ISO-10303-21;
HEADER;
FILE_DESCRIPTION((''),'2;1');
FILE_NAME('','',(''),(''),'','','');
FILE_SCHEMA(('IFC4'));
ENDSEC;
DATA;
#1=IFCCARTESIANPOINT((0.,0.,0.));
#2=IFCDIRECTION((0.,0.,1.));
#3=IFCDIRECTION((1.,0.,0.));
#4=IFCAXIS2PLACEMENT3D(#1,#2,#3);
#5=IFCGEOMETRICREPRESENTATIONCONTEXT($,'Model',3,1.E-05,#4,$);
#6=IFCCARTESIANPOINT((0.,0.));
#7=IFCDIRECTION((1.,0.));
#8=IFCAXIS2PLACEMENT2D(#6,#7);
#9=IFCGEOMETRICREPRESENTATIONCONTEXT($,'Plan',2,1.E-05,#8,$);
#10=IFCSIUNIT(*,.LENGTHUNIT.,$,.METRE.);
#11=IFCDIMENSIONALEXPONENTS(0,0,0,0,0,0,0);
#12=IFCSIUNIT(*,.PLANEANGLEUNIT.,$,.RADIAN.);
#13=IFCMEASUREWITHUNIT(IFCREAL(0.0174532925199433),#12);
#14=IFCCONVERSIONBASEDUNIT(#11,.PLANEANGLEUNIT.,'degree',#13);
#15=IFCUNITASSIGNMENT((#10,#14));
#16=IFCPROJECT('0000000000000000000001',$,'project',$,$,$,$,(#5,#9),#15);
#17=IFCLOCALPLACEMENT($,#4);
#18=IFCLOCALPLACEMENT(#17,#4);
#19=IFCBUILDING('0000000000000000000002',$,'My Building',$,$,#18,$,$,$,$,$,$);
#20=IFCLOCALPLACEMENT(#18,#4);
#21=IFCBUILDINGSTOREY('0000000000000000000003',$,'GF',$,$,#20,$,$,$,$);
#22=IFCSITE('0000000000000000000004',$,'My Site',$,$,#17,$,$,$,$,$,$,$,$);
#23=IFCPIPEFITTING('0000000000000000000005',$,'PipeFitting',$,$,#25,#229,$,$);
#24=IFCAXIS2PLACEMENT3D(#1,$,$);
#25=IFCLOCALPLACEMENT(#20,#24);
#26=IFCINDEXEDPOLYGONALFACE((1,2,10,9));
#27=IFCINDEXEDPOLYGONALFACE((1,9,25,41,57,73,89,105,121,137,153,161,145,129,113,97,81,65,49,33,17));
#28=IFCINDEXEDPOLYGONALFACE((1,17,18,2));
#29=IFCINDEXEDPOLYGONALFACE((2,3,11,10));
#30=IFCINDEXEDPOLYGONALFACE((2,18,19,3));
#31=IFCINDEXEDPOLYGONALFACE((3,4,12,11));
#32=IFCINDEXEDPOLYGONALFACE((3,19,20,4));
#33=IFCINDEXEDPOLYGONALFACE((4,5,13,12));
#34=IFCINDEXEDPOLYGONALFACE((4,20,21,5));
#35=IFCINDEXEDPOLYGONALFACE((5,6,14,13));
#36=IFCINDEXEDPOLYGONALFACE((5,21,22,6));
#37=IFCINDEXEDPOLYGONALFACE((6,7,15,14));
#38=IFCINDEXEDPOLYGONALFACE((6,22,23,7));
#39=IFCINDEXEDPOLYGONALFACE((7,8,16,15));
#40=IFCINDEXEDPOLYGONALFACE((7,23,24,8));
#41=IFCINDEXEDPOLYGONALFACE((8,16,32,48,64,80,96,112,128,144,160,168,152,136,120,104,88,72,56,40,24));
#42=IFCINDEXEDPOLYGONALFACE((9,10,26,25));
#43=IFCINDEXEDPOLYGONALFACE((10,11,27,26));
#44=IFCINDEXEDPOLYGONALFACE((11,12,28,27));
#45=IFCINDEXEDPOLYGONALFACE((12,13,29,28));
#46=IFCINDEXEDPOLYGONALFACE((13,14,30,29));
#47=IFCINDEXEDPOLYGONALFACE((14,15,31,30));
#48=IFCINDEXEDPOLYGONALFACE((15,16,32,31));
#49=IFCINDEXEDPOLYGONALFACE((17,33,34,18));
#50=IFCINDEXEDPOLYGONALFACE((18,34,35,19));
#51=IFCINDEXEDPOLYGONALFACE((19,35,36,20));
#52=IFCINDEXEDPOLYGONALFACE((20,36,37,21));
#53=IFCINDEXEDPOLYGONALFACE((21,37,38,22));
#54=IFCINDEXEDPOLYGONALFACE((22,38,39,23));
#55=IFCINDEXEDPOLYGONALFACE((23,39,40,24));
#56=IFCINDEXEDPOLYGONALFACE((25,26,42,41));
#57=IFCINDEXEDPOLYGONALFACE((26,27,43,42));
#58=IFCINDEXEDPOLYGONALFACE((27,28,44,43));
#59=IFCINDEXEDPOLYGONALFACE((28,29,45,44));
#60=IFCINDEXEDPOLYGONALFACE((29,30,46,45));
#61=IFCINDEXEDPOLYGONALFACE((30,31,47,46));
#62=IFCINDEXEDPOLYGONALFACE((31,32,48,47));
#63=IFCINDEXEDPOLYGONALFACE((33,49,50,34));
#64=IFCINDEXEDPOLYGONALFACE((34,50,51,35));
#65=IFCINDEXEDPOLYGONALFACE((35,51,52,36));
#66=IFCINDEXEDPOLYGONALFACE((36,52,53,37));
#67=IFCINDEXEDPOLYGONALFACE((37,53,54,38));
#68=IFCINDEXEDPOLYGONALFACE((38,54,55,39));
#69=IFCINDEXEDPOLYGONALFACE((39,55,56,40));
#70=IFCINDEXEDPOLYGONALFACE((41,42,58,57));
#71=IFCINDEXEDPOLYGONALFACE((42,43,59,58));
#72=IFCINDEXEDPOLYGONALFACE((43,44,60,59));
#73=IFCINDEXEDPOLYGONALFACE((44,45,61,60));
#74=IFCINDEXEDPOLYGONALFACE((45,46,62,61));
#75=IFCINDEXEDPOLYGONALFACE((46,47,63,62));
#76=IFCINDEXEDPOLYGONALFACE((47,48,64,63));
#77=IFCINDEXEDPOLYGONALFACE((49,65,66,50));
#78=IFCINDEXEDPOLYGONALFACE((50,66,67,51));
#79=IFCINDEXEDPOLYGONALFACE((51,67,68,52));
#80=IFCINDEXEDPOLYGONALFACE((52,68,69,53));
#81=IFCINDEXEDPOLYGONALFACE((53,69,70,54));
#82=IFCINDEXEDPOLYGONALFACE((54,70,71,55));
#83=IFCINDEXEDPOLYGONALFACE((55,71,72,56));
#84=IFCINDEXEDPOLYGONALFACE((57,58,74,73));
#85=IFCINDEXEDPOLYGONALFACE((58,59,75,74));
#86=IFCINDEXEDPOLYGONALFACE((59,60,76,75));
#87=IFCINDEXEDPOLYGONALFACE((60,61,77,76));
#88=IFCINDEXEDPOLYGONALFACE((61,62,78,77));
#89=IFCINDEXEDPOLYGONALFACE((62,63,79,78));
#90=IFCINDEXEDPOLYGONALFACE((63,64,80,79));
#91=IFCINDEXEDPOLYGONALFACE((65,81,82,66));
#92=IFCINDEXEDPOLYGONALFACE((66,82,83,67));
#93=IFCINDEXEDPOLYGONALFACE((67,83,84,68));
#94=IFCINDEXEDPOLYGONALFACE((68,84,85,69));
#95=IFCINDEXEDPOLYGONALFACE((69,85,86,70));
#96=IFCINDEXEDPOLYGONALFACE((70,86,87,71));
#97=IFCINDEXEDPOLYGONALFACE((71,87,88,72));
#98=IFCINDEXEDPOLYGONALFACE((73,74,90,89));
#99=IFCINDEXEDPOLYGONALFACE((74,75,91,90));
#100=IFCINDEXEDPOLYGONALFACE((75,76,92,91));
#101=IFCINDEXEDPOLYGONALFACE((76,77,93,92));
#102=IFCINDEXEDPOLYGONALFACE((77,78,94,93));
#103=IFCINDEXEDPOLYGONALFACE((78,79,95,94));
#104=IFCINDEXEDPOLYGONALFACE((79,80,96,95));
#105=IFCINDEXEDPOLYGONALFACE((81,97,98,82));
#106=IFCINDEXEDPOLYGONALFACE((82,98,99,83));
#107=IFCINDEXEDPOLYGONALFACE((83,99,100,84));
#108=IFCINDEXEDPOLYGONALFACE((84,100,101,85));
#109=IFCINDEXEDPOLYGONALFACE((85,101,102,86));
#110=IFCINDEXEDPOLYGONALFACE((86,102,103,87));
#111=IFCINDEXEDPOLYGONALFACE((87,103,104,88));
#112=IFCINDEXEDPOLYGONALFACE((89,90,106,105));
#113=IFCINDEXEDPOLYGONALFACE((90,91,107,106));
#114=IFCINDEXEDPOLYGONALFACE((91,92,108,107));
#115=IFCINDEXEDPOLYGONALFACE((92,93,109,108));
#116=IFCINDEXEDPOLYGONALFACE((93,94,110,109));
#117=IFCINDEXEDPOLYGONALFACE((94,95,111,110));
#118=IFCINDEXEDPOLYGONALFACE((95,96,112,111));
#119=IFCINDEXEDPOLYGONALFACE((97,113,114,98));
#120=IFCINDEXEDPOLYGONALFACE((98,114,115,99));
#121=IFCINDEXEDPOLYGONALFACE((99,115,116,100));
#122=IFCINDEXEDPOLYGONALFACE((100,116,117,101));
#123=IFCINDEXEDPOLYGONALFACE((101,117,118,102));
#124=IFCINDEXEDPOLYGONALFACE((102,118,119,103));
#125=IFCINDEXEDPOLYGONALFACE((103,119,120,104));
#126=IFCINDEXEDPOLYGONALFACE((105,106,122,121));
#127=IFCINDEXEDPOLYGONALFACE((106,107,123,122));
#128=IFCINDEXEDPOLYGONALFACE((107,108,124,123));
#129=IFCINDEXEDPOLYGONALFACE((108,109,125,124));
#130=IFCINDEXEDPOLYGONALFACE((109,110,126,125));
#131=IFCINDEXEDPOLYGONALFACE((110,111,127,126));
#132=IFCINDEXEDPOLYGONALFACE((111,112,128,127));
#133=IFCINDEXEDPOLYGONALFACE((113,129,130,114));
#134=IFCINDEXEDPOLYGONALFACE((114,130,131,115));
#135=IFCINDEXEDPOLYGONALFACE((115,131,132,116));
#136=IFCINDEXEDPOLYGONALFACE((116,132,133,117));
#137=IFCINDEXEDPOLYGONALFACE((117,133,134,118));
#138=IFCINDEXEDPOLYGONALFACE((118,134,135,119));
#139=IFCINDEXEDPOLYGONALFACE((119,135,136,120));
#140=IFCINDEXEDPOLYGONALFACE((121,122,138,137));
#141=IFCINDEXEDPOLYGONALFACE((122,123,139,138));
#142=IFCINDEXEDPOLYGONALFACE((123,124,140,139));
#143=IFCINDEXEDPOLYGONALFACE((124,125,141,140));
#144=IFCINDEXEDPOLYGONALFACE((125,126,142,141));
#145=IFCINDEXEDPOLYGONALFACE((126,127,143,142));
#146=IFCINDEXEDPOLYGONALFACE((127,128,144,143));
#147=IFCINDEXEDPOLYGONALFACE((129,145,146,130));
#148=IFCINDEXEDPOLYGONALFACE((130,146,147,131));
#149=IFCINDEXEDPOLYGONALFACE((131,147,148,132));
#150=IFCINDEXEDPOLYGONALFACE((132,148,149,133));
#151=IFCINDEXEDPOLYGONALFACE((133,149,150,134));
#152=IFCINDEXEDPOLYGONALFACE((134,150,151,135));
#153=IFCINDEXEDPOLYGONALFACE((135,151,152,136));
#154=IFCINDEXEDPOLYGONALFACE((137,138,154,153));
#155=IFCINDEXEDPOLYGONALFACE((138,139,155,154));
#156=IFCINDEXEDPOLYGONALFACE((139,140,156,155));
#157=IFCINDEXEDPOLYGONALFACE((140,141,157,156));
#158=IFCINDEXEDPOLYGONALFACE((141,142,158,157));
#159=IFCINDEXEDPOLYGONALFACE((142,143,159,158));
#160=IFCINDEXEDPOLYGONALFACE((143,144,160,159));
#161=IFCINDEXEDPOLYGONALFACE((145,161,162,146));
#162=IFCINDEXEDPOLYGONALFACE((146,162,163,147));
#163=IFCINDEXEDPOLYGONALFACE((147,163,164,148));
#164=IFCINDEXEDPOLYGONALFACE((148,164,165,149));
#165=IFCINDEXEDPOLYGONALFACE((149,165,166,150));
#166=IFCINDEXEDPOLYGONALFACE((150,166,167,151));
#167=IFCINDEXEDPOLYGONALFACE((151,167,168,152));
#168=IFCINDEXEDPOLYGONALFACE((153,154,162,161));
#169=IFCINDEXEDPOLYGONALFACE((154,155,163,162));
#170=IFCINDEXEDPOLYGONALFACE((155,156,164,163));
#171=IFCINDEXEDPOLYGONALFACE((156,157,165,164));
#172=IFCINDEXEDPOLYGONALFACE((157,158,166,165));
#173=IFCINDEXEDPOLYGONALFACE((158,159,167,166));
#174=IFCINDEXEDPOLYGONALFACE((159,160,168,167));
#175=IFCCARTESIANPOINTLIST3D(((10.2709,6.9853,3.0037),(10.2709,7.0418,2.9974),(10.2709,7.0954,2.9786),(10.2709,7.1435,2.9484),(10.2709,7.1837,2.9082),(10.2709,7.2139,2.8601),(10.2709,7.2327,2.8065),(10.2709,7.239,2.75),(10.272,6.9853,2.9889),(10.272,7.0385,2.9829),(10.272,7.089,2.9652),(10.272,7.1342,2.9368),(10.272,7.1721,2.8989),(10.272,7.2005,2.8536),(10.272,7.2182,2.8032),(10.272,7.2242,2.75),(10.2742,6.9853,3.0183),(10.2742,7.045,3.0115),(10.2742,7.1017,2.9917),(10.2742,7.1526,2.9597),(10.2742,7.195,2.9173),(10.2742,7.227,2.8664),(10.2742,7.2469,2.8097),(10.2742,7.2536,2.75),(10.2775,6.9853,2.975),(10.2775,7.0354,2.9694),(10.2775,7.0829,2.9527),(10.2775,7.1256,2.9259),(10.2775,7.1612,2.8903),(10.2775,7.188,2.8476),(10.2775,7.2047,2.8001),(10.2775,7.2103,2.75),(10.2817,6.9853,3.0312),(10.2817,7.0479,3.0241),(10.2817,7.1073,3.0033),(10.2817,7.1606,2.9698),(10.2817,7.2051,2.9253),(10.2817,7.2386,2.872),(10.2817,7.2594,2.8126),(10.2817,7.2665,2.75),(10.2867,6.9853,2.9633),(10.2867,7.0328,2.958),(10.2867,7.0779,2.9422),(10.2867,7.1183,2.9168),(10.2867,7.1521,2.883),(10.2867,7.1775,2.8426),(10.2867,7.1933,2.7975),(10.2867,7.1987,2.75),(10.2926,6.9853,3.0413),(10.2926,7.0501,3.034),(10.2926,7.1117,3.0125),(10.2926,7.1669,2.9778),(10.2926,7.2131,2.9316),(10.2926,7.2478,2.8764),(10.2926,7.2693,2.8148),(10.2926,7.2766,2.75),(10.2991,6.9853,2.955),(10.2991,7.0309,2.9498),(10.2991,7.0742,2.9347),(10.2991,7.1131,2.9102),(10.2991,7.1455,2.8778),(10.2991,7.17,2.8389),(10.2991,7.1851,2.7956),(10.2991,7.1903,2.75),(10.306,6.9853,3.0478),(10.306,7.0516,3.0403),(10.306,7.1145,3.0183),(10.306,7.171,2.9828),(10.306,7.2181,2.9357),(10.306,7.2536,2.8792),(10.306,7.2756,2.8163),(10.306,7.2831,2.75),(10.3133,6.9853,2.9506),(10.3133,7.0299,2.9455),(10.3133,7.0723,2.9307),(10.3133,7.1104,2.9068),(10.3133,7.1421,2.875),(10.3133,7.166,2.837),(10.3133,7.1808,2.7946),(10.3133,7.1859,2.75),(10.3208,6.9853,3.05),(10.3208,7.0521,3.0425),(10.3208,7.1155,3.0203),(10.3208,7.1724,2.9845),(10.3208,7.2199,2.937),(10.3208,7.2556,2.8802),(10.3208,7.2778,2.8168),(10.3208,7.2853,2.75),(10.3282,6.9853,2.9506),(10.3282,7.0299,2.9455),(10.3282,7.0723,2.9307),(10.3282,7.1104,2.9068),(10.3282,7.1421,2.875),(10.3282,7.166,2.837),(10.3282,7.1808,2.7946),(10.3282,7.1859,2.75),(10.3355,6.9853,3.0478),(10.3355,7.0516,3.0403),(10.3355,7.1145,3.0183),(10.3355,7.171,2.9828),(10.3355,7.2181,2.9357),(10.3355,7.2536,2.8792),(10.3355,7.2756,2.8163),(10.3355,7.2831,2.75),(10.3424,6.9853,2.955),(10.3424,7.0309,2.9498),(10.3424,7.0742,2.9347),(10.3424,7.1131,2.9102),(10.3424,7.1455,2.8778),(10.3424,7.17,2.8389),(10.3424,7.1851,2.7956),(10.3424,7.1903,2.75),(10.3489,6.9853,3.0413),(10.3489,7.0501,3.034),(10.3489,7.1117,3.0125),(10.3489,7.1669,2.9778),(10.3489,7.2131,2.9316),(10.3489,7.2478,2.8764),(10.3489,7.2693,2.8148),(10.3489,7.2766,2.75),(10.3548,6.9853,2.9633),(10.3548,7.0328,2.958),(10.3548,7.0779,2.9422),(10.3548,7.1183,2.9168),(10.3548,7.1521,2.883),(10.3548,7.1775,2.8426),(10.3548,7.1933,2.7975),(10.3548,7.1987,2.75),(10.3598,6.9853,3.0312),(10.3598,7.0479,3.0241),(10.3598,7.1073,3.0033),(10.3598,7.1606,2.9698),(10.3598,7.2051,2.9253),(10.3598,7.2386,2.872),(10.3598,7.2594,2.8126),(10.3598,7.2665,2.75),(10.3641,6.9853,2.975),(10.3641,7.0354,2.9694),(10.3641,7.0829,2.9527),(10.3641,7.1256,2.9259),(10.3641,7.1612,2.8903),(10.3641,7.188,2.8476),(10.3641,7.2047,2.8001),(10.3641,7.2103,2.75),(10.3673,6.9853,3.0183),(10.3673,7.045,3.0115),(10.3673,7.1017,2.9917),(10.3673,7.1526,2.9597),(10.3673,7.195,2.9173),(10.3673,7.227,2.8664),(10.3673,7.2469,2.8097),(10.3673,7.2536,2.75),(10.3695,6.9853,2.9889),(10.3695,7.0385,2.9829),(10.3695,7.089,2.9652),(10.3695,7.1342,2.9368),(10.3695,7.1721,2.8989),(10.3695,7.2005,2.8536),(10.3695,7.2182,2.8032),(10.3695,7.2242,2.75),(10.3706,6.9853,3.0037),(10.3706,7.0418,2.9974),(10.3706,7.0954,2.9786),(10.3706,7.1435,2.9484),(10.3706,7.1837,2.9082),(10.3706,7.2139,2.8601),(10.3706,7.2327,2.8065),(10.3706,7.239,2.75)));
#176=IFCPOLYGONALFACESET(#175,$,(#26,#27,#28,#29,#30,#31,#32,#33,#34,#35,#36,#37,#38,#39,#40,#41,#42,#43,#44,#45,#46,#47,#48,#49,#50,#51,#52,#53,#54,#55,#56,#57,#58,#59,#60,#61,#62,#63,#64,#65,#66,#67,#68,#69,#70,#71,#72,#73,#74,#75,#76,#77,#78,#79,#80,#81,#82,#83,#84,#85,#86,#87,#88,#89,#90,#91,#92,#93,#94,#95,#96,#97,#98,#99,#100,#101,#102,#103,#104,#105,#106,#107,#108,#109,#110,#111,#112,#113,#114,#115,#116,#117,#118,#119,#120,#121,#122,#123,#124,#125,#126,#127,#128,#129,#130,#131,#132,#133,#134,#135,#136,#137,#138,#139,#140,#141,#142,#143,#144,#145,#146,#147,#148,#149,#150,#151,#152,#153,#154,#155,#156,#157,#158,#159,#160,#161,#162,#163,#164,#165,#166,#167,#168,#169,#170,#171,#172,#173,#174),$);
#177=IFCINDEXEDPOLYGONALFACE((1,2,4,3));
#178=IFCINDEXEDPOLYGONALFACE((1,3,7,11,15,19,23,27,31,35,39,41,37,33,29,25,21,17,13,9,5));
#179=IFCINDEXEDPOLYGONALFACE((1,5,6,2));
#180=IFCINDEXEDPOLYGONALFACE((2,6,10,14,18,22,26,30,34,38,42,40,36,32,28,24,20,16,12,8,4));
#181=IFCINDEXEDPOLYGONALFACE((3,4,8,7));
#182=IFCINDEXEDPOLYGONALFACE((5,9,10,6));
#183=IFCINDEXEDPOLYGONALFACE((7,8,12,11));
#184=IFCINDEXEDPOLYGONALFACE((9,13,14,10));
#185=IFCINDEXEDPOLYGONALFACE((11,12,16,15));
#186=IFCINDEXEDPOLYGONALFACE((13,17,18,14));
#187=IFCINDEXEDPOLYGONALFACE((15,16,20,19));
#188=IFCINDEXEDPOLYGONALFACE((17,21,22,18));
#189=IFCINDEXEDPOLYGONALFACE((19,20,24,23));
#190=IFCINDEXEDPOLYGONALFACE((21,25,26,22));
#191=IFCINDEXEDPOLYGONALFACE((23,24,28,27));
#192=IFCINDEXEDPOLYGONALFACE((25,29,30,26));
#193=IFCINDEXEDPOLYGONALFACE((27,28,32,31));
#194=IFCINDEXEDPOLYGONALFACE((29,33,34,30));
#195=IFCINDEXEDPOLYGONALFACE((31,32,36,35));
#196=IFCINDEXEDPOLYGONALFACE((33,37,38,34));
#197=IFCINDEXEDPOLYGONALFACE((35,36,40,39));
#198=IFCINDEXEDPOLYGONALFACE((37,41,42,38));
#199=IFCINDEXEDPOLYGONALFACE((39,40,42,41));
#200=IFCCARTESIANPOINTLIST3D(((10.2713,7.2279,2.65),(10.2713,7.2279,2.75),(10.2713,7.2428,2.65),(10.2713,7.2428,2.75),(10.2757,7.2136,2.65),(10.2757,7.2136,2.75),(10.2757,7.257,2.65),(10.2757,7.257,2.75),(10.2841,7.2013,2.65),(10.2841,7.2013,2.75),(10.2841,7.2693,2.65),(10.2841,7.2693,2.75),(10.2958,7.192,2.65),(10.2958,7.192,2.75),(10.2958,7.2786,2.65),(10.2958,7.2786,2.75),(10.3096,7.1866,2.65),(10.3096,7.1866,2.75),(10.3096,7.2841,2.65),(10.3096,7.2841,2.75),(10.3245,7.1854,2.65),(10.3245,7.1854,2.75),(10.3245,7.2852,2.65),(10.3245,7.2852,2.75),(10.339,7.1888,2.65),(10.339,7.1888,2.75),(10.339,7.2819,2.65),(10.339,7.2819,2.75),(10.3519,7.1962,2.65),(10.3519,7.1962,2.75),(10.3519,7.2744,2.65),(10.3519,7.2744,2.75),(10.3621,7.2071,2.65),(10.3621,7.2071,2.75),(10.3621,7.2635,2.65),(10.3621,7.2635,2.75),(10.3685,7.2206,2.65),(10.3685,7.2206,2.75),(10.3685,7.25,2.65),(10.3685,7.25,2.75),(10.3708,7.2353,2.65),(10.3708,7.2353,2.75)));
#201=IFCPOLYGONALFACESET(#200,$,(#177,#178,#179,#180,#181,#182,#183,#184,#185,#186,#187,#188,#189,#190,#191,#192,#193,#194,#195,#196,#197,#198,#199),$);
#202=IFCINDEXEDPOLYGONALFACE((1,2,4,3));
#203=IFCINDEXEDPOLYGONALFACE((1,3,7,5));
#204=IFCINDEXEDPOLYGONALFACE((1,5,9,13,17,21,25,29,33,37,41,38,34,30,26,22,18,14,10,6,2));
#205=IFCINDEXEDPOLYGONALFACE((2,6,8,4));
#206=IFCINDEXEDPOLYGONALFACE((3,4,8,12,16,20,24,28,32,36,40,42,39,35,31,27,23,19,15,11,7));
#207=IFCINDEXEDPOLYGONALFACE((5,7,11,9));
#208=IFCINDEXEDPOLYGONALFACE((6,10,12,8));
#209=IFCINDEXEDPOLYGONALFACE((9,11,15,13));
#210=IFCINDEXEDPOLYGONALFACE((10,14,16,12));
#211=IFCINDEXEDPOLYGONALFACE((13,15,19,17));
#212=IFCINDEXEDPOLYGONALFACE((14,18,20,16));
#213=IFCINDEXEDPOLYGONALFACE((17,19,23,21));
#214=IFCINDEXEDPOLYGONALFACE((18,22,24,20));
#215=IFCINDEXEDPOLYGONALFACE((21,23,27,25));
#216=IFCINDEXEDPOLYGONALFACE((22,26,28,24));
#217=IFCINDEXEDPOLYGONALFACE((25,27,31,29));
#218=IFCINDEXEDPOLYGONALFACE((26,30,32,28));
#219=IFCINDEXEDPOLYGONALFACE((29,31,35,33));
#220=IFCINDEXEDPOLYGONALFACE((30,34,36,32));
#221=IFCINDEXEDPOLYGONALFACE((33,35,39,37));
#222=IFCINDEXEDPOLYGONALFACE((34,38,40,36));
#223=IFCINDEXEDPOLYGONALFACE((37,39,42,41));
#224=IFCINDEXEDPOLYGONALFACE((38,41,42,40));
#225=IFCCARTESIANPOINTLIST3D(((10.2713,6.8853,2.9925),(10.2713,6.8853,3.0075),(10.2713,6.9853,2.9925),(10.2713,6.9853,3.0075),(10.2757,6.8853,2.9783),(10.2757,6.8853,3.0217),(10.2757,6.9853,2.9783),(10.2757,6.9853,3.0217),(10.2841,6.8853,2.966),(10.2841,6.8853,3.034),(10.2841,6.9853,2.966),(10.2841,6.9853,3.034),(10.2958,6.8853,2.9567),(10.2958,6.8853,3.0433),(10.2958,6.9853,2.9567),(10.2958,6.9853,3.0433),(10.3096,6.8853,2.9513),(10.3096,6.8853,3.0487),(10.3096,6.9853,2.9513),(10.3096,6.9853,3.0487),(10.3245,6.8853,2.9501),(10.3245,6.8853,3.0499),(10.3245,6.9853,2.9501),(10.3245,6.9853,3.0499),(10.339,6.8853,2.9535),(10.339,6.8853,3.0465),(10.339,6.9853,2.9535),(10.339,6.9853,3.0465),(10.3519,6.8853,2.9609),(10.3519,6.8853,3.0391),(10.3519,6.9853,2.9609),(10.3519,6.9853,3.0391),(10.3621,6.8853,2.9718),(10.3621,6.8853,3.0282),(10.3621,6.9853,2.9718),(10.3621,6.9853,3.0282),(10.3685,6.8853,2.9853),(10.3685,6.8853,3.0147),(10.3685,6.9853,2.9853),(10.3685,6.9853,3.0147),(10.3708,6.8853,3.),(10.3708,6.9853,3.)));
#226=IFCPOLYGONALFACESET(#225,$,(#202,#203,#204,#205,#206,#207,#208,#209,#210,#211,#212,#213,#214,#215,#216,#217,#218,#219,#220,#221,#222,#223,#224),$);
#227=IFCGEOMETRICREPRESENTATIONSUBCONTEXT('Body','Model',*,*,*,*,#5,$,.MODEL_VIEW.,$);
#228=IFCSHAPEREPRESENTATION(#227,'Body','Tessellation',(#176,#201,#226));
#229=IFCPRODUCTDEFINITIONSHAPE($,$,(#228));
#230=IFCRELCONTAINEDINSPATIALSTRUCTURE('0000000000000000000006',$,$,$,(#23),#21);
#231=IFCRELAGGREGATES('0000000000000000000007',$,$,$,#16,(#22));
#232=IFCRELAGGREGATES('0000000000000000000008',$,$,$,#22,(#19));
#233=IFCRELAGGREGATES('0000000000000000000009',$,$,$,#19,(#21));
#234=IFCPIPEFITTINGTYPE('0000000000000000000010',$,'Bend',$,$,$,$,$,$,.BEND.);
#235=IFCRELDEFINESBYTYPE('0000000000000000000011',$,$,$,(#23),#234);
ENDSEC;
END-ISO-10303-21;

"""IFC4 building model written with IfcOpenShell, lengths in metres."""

from ifc_helpers import new_model, entity, si_unit, converted_unit, frame, origin_with_axes, origin_2d_with_axis, place, context, subcontext, project, spatial, circle, extrude, source, transform, mapped, type_object, type_shapes, element, save


model = new_model("IFC4")

# Units and contexts
model_context = context("Model", 3, precision=1e-05, world=origin_with_axes())
plan_context = context("Plan", 2, precision=1e-05, world=origin_2d_with_axis())
body_context = subcontext(model_context, "Body", "Model", "MODEL_VIEW")
ifc_project = project(units=[si_unit("LENGTHUNIT", "METRE"), converted_unit("PLANEANGLEUNIT", "degree", entity("IfcReal", 0.0174532925199433), si_unit("PLANEANGLEUNIT", "RADIAN"), dimensions=[0, 0, 0, 0, 0, 0, 0])], contexts=[model_context, plan_context])

# Site, building, storey
site_placement = place(None, origin_with_axes())
site = spatial("IfcSite", under=ifc_project, at=site_placement, Name="My Site")
building_placement = place(site_placement, origin_with_axes())
building = spatial("IfcBuilding", under=site, at=building_placement, Name="My Building")
storey_placement = place(building_placement, origin_with_axes())
storey = spatial("IfcBuildingStorey", under=building, at=storey_placement, Name="GF")

# Pipe fitting
pipe_fitting_type = type_object("IfcPipeFittingType", Name="Bend", PredefinedType="BEND")
shared_shape = source(origin_with_axes(), body_context, "Body", "SolidModel", [
    entity("IfcSweptDiskSolid", entity("IfcIndexedPolyCurve", entity("IfcCartesianPointList3D", [[0.0, 0.0, -0.1], [0.0, 0.0732, -0.2768], [0.0, 0.25, -0.35]]), [entity("IfcArcIndex", [1, 2, 3])]), 0.05),
    extrude(circle(Radius=0.05), origin_with_axes(), (0.0, 0.0, -1.0), 0.1),
    extrude(circle(Radius=0.05), frame((0.0, 0.25, -0.35), z_axis=(0.0, 1.0, 0.0), x_axis=(1.0, 0.0, 0.0)), (0.0, 0.0, 1.0), 0.1),
])
type_shapes(pipe_fitting_type, [shared_shape])
for number, where, z_axis, x_axis, name in (
    (1, (10.3208, 7.2353, 2.65), (0.0, 0.0, -1.0), (1.0, 0.0, 0.0), "PipeFitting"),
):
    element("IfcPipeFitting", number, at=place(storey_placement, frame(where, z_axis=z_axis, x_axis=x_axis)), inside=storey, type_object=pipe_fitting_type, Name=name, context=body_context, shape_type="MappedRepresentation", body=[
        mapped(shared_shape, transform((0.0, 0.0, 0.0), x_axis=(1.0, 0.0, 0.0), y_axis=(0.0, 1.0, 0.0), z_axis=(0.0, 0.0, 1.0), scale=1.0)),
    ])

save(model, "model.ifc")
